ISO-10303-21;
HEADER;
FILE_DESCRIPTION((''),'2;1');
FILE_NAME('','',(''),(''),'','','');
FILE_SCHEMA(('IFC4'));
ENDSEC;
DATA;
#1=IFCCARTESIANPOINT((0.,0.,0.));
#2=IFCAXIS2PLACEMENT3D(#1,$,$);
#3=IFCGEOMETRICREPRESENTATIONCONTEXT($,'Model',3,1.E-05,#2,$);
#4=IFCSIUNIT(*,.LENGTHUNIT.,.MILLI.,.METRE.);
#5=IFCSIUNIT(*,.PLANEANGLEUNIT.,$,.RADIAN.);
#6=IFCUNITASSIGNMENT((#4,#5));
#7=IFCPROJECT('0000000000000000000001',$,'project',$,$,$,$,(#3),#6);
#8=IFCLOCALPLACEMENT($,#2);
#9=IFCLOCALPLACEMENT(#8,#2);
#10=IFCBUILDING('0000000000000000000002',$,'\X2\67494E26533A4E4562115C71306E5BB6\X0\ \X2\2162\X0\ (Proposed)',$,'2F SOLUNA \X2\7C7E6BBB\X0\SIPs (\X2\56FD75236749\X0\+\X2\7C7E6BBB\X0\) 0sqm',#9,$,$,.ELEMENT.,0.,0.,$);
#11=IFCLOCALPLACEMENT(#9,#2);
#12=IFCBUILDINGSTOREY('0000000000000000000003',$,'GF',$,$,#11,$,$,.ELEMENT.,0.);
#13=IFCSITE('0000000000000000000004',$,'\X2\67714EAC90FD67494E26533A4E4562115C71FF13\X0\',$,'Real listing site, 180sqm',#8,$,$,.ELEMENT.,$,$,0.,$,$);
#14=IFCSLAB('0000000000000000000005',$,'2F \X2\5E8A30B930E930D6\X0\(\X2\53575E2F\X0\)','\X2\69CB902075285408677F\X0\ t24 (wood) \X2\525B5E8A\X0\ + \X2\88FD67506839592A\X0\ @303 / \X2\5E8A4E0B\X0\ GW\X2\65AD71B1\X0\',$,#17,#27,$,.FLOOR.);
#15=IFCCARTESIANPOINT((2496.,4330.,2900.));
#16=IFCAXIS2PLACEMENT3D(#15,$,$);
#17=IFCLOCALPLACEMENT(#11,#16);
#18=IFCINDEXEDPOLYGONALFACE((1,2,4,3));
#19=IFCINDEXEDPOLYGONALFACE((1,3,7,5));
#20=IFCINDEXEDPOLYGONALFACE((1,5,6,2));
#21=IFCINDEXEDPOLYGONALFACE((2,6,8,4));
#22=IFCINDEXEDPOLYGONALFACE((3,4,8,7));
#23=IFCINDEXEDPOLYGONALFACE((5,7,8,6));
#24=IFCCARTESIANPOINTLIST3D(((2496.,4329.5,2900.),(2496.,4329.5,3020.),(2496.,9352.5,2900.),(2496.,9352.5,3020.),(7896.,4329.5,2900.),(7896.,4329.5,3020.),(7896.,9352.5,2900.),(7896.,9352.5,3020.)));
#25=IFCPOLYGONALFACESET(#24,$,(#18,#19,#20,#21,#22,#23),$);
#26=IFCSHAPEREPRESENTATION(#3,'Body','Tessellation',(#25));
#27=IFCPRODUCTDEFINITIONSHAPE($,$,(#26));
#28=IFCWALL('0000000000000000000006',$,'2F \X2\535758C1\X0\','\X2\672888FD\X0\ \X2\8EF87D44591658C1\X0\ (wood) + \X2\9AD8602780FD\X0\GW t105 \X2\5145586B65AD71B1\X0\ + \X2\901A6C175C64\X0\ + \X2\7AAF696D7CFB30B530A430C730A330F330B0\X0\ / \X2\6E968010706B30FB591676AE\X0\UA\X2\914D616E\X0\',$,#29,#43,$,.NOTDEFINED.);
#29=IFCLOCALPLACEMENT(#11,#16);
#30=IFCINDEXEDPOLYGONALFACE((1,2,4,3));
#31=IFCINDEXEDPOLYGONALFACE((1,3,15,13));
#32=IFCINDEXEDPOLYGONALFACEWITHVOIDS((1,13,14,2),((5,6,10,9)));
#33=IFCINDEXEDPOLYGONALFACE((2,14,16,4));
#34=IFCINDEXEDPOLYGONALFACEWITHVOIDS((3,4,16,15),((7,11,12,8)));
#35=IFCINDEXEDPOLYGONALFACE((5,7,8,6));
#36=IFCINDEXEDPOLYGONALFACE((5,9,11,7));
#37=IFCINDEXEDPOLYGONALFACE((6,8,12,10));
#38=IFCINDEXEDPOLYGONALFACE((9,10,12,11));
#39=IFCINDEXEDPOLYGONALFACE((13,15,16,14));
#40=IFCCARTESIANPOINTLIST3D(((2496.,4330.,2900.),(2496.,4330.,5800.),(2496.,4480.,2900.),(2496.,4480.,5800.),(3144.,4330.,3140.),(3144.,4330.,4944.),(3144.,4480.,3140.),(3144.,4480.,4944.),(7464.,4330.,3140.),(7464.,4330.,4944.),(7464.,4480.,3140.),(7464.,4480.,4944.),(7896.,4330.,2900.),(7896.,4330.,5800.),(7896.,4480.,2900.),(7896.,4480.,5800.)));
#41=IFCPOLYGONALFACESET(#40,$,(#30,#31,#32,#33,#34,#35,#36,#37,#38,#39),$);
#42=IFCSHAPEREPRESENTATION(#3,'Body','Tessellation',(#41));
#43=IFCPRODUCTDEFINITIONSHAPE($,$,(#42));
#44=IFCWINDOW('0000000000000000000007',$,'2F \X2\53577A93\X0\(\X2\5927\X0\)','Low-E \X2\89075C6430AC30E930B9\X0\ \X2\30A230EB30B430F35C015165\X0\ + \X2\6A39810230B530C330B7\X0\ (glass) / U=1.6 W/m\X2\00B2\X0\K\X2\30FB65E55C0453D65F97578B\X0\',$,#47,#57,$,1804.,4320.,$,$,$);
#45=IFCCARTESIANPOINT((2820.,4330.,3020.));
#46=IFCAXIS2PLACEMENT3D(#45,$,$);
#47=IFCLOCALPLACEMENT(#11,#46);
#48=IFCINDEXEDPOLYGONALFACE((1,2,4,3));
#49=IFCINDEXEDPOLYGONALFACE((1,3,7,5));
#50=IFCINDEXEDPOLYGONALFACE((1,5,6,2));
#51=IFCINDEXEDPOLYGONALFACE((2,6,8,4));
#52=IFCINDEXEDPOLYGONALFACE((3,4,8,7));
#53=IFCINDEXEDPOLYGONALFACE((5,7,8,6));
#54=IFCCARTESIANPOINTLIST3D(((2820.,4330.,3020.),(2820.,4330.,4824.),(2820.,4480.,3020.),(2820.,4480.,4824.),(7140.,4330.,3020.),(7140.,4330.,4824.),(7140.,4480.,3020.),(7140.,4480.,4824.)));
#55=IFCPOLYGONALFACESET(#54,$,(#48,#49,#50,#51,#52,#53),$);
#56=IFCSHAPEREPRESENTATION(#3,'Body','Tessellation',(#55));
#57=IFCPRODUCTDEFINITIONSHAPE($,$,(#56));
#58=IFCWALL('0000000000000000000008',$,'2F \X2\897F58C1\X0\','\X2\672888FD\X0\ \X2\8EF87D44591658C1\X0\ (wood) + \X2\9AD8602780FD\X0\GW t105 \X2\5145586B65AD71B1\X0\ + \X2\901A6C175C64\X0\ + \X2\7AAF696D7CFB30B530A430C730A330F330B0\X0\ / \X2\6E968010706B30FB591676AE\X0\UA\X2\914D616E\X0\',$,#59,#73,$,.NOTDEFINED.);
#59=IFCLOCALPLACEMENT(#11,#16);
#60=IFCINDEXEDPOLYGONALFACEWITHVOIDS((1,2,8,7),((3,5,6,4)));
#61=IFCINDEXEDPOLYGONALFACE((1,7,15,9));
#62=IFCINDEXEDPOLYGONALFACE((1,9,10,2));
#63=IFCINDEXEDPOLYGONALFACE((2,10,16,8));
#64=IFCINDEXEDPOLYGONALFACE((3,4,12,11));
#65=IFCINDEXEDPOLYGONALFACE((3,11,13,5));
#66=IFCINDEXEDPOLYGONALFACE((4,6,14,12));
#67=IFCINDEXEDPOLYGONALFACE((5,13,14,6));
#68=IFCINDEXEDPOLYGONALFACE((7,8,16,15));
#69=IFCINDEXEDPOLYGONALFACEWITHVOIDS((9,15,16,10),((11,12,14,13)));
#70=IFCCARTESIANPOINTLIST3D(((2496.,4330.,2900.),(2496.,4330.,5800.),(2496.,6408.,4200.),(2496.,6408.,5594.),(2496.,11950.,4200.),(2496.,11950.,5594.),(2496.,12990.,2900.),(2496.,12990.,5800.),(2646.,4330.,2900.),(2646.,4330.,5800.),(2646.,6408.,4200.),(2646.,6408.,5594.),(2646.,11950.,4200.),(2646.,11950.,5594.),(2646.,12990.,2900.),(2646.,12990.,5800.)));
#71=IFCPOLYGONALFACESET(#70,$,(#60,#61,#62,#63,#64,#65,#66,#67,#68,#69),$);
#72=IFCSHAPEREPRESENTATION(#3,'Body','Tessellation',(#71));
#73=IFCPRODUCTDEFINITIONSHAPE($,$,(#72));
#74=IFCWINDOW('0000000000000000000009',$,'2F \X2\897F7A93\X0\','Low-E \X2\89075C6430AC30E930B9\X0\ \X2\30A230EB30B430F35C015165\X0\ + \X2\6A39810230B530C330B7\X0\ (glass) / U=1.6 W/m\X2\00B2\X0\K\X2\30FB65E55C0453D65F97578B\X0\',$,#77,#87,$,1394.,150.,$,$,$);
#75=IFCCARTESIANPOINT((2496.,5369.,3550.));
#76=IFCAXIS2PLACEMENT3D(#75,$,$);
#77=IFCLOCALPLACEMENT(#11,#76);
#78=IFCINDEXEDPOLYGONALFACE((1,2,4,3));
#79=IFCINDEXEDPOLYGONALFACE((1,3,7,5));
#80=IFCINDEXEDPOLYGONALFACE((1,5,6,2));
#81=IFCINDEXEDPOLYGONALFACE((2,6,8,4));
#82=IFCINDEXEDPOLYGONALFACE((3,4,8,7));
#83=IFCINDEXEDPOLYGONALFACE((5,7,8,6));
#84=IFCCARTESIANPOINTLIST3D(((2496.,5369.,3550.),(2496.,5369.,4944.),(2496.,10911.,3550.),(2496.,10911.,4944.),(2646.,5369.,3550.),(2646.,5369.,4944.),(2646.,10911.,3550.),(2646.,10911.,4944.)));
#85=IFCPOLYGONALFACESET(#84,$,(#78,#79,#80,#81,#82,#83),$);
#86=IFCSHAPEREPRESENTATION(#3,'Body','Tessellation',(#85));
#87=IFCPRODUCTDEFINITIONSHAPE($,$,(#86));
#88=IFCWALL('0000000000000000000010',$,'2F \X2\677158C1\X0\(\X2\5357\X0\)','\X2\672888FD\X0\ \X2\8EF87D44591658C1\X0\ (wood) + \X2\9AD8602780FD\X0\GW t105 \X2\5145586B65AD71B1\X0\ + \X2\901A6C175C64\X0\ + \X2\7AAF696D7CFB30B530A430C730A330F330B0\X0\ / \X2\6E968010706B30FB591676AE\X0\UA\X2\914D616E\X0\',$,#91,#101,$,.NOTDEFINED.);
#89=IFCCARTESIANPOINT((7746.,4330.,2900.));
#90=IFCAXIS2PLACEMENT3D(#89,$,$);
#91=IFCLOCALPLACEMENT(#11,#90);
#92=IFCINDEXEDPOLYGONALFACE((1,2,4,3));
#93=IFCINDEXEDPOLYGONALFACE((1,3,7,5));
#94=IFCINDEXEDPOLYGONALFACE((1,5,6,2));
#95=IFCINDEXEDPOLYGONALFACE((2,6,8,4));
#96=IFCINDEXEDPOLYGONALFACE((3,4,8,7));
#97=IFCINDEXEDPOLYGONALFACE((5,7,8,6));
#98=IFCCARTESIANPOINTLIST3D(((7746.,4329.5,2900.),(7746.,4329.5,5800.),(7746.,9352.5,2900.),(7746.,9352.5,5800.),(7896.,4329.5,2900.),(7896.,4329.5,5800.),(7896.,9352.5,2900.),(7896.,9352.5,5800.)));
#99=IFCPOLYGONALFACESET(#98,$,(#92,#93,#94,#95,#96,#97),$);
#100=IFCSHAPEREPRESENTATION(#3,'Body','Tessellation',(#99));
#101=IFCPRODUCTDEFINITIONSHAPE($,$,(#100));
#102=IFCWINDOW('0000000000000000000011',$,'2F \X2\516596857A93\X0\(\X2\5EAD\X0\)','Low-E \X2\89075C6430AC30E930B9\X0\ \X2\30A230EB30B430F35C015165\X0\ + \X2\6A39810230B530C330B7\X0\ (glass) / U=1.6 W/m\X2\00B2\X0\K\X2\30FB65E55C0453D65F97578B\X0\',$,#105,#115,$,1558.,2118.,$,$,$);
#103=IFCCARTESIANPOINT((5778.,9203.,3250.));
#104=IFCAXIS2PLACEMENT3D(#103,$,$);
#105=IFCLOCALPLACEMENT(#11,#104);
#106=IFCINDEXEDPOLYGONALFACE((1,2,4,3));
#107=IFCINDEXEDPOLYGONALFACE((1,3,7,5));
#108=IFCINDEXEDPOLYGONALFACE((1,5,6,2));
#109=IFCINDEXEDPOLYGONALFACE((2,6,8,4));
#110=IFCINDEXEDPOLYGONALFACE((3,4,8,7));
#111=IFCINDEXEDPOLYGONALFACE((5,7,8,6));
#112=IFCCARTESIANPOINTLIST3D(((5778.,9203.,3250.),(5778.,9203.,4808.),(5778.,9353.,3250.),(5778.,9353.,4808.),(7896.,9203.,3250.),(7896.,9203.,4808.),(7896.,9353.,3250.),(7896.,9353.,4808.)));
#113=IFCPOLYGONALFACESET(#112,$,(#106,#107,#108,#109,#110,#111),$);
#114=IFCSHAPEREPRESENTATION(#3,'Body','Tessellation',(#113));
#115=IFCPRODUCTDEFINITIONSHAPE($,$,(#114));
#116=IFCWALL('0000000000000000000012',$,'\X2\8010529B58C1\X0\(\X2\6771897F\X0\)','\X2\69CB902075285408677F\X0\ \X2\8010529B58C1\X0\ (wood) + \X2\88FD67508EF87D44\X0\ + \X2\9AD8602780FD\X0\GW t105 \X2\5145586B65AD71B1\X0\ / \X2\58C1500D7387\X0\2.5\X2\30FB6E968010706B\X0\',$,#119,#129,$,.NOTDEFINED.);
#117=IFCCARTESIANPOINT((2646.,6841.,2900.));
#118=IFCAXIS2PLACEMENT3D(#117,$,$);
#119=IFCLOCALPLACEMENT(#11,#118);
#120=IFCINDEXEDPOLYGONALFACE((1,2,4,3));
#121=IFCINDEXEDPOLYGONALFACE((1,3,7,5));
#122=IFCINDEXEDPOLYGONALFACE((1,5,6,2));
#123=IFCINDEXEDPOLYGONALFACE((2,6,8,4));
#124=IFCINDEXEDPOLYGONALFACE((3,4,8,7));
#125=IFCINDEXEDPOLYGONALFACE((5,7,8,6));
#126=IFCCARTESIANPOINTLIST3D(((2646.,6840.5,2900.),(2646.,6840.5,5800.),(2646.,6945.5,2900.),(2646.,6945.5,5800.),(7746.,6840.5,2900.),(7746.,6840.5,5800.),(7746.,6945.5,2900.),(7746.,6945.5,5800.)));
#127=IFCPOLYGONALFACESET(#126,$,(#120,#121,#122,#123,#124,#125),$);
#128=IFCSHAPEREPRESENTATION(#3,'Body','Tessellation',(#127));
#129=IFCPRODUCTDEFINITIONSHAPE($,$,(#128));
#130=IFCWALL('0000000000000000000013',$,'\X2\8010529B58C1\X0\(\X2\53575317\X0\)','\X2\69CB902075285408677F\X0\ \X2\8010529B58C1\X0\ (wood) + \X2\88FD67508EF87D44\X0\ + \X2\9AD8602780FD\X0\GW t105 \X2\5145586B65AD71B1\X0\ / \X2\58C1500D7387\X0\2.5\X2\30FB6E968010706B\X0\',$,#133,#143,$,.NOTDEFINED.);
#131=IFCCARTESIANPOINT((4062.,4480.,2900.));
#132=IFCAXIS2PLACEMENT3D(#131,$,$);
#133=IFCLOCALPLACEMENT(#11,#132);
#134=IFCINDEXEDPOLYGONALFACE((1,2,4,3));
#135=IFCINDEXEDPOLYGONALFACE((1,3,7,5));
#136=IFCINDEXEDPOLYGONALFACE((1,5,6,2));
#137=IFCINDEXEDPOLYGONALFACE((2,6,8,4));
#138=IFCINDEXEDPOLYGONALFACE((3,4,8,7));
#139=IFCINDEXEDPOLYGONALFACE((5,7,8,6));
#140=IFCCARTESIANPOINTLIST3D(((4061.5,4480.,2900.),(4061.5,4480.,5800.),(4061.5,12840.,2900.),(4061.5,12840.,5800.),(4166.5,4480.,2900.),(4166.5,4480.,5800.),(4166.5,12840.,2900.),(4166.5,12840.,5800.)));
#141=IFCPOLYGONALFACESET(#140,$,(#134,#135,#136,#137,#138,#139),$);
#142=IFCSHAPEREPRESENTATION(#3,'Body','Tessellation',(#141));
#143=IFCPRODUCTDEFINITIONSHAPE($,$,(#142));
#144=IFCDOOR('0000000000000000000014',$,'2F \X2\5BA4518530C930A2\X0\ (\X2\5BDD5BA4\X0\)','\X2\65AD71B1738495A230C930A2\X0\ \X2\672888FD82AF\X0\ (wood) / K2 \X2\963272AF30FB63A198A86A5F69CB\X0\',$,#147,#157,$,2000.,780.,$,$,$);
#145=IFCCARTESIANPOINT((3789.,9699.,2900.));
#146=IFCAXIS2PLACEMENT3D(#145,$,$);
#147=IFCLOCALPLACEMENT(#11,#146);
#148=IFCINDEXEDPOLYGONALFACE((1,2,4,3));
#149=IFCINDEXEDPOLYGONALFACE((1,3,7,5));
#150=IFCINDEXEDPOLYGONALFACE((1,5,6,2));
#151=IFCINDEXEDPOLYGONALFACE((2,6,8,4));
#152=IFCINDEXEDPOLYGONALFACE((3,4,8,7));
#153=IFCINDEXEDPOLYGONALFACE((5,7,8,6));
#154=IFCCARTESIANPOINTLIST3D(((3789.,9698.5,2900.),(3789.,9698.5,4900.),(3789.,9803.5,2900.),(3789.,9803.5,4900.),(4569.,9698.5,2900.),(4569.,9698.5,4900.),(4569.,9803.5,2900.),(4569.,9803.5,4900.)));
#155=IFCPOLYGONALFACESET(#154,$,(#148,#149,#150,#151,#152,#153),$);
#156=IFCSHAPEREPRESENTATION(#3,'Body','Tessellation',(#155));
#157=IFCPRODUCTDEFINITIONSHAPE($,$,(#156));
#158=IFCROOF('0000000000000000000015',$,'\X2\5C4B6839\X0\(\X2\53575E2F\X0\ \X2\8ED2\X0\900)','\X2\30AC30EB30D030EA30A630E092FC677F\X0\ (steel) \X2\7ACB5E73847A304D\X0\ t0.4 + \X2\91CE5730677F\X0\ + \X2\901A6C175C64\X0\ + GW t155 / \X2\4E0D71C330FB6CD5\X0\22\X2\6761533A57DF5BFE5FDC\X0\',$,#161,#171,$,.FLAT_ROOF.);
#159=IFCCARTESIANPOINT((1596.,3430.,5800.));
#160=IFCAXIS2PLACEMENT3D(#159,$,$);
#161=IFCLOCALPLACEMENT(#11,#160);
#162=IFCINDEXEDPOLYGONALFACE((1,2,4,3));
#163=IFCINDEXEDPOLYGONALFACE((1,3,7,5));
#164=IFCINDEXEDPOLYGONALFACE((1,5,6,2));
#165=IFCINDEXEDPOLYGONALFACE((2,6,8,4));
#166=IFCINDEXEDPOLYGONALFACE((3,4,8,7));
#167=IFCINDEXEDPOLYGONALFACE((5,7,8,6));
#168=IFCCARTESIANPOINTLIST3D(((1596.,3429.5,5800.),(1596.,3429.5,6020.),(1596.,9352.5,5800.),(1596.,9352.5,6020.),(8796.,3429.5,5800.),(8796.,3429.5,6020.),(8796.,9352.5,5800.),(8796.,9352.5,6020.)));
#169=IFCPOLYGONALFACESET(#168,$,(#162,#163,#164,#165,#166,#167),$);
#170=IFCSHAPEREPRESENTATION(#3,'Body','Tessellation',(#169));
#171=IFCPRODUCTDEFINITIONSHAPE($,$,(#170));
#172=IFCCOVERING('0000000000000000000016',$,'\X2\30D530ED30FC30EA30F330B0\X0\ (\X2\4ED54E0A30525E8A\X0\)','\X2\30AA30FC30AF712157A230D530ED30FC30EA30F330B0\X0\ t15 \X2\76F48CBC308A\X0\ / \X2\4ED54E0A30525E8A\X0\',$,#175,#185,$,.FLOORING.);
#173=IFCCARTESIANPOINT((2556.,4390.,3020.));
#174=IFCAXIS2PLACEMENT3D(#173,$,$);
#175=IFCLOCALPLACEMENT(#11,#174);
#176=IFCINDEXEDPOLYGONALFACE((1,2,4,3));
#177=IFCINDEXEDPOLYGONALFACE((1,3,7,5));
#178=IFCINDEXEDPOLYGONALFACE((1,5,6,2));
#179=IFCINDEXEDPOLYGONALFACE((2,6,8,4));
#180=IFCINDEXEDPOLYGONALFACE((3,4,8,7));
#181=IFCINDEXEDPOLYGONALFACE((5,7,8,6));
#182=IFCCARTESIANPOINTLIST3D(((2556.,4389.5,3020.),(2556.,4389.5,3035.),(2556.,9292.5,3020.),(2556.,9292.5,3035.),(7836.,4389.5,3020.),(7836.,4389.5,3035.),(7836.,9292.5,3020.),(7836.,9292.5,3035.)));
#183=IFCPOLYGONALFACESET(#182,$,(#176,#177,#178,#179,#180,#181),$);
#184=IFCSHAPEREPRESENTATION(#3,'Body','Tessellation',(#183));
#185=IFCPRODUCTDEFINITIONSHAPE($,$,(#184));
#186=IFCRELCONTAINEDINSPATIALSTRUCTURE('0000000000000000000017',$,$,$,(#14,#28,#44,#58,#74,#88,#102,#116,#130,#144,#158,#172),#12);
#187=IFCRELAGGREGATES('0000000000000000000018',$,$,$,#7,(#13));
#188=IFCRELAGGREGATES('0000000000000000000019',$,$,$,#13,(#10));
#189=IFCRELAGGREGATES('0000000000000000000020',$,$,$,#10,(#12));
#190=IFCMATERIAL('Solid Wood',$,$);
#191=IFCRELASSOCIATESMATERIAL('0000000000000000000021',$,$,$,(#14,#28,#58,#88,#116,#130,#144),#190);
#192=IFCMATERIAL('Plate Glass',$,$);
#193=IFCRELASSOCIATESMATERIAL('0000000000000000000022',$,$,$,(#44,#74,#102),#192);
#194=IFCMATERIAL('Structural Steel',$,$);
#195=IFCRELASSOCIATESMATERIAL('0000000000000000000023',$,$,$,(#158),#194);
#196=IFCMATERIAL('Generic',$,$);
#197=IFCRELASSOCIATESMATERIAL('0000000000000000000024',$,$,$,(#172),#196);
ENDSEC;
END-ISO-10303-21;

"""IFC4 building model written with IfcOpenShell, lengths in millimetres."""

from ifc_helpers import new_model, si_unit, frame, frame_2d, origin, place, context, project, spatial, rectangle, extrude, material, element, fill, save


model = new_model("IFC4")

# Units and contexts
model_context = context("Model", 3, precision=1e-05, world=origin())
ifc_project = project(units=[si_unit("LENGTHUNIT", "METRE", prefix="MILLI"), si_unit("PLANEANGLEUNIT", "RADIAN")], contexts=[model_context])

# Site, building, storey
site_placement = place(None, origin())
site = spatial("IfcSite", under=ifc_project, at=site_placement, Name="東京都杉並区久我山３", ObjectType="Real listing site, 180sqm", CompositionType="ELEMENT", RefElevation=0.0)
building_placement = place(site_placement, origin())
building = spatial("IfcBuilding", under=site, at=building_placement, Name="杉並区久我山の家 Ⅲ (Proposed)", ObjectType="2F SOLUNA 籾殻SIPs (国産杉+籾殻) 0sqm", CompositionType="ELEMENT", ElevationOfRefHeight=0.0, ElevationOfTerrain=0.0)
storey_placement = place(building_placement, origin())
storey = spatial("IfcBuildingStorey", under=building, at=storey_placement, Name="GF", CompositionType="ELEMENT", Elevation=0.0)

# Slab
ifc_material_1 = material(Name="Solid Wood")
slab_placement = place(storey_placement, frame((2496.0, 4330.0, 2900.0)))
element("IfcSlab", 1, at=slab_placement, inside=storey, material=ifc_material_1, Name="2F 床スラブ(南帯)", Description="構造用合板 t24 (wood) 剛床 + 製材根太 @303 / 床下 GW断熱", PredefinedType="FLOOR", context=model_context, shape_type="SweptSolid", body=[
    extrude(rectangle(XDim=5400.0, YDim=5023.0, at=frame_2d((2700.0, 2511.0))), frame((2496.0, 4330.0, 2900.0)), (0.0, 0.0, 1.0), 120.0),
])

# Walls, openings, windows
wall_1_placement = place(storey_placement, frame((2496.0, 4330.0, 2900.0)))
wall_1 = element("IfcWall", 2, at=wall_1_placement, inside=storey, material=ifc_material_1, Name="2F 南壁", Description="木製 軸組外壁 (wood) + 高性能GW t105 充填断熱 + 通気層 + 窯業系サイディング / 準耐火・外皮UA配慮", PredefinedType="NOTDEFINED", context=model_context, shape_type="SweptSolid", body=[
    extrude(rectangle(XDim=5400.0, YDim=150.0, at=frame_2d((2700.0, 75.0))), frame((2496.0, 4330.0, 2900.0)), (0.0, 0.0, 1.0), 2900.0),
])
opening_1_placement = place(storey_placement, frame((2820.0, 4330.0, 3020.0)))
opening_1 = element("IfcOpeningElement", 3, at=opening_1_placement, cuts=wall_1, PredefinedType="NOTDEFINED", context=model_context, shape_type="SweptSolid", body=[
    extrude(rectangle(XDim=4320.0, YDim=150.0, at=frame_2d((2160.0, 75.0))), frame((2820.0, 4330.0, 3020.0)), (0.0, 0.0, 1.0), 1804.0),
])
ifc_material_2 = material(Name="Plate Glass")
window_1_placement = place(storey_placement, frame((2820.0, 4330.0, 3020.0)))
window_1 = element("IfcWindow", 4, at=window_1_placement, inside=storey, material=ifc_material_2, Name="2F 南窓(大)", Description="Low-E 複層ガラス アルゴン封入 + 樹脂サッシ (glass) / U=1.6 W/m²K・日射取得型", OverallHeight=1804.0, OverallWidth=4320.0, context=model_context, shape_type="SweptSolid", body=[
    extrude(rectangle(XDim=4320.0, YDim=150.0, at=frame_2d((2160.0, 75.0))), frame((2820.0, 4330.0, 3020.0)), (0.0, 0.0, 1.0), 1804.0),
])
fill(opening_1, window_1)
wall_2_placement = place(storey_placement, frame((2496.0, 4330.0, 2900.0)))
wall_2 = element("IfcWall", 5, at=wall_2_placement, inside=storey, material=ifc_material_1, Name="2F 西壁", Description="木製 軸組外壁 (wood) + 高性能GW t105 充填断熱 + 通気層 + 窯業系サイディング / 準耐火・外皮UA配慮", PredefinedType="NOTDEFINED", context=model_context, shape_type="SweptSolid", body=[
    extrude(rectangle(XDim=150.0, YDim=8660.0, at=frame_2d((75.0, 4330.0))), frame((2496.0, 4330.0, 2900.0)), (0.0, 0.0, 1.0), 2900.0),
])
opening_2_placement = place(storey_placement, frame((2496.0, 5369.0, 3550.0)))
opening_2 = element("IfcOpeningElement", 6, at=opening_2_placement, cuts=wall_2, PredefinedType="NOTDEFINED", context=model_context, shape_type="SweptSolid", body=[
    extrude(rectangle(XDim=150.0, YDim=5542.0, at=frame_2d((75.0, 2771.0))), frame((2496.0, 5369.0, 3550.0)), (0.0, 0.0, 1.0), 1394.0),
])
window_2_placement = place(storey_placement, frame((2496.0, 5369.0, 3550.0)))
window_2 = element("IfcWindow", 7, at=window_2_placement, inside=storey, material=ifc_material_2, Name="2F 西窓", Description="Low-E 複層ガラス アルゴン封入 + 樹脂サッシ (glass) / U=1.6 W/m²K・日射取得型", OverallHeight=1394.0, OverallWidth=150.0, context=model_context, shape_type="SweptSolid", body=[
    extrude(rectangle(XDim=150.0, YDim=5542.0, at=frame_2d((75.0, 2771.0))), frame((2496.0, 5369.0, 3550.0)), (0.0, 0.0, 1.0), 1394.0),
])
fill(opening_2, window_2)
wall_3_placement = place(storey_placement, frame((7746.0, 4330.0, 2900.0)))
wall_3 = element("IfcWall", 8, at=wall_3_placement, inside=storey, material=ifc_material_1, Name="2F 東壁(南)", Description="木製 軸組外壁 (wood) + 高性能GW t105 充填断熱 + 通気層 + 窯業系サイディング / 準耐火・外皮UA配慮", PredefinedType="NOTDEFINED", context=model_context, shape_type="SweptSolid", body=[
    extrude(rectangle(XDim=150.0, YDim=5023.0, at=frame_2d((75.0, 2511.0))), frame((7746.0, 4330.0, 2900.0)), (0.0, 0.0, 1.0), 2900.0),
])
opening_3_placement = place(storey_placement, frame((5778.0, 9203.0, 3250.0)))
opening_3 = element("IfcOpeningElement", 9, at=opening_3_placement, cuts=wall_3, PredefinedType="NOTDEFINED", context=model_context, shape_type="SweptSolid", body=[
    extrude(rectangle(XDim=2118.0, YDim=150.0, at=frame_2d((1059.0, 75.0))), frame((5778.0, 9203.0, 3250.0)), (0.0, 0.0, 1.0), 1558.0),
])
window_3_placement = place(storey_placement, frame((5778.0, 9203.0, 3250.0)))
window_3 = element("IfcWindow", 10, at=window_3_placement, inside=storey, material=ifc_material_2, Name="2F 入隅窓(庭)", Description="Low-E 複層ガラス アルゴン封入 + 樹脂サッシ (glass) / U=1.6 W/m²K・日射取得型", OverallHeight=1558.0, OverallWidth=2118.0, context=model_context, shape_type="SweptSolid", body=[
    extrude(rectangle(XDim=2118.0, YDim=150.0, at=frame_2d((1059.0, 75.0))), frame((5778.0, 9203.0, 3250.0)), (0.0, 0.0, 1.0), 1558.0),
])
fill(opening_3, window_3)

# Wall
wall_4_placement = place(storey_placement, frame((2646.0, 6841.0, 2900.0)))
element("IfcWall", 11, at=wall_4_placement, inside=storey, material=ifc_material_1, Name="耐力壁(東西)", Description="構造用合板 耐力壁 (wood) + 製材軸組 + 高性能GW t105 充填断熱 / 壁倍率2.5・準耐火", PredefinedType="NOTDEFINED", context=model_context, shape_type="SweptSolid", body=[
    extrude(rectangle(XDim=5100.0, YDim=105.0, at=frame_2d((2550.0, 52.0))), frame((2646.0, 6841.0, 2900.0)), (0.0, 0.0, 1.0), 2900.0),
])

# Wall, opening, door
wall_5_placement = place(storey_placement, frame((4062.0, 4480.0, 2900.0)))
wall_5 = element("IfcWall", 12, at=wall_5_placement, inside=storey, material=ifc_material_1, Name="耐力壁(南北)", Description="構造用合板 耐力壁 (wood) + 製材軸組 + 高性能GW t105 充填断熱 / 壁倍率2.5・準耐火", PredefinedType="NOTDEFINED", context=model_context, shape_type="SweptSolid", body=[
    extrude(rectangle(XDim=105.0, YDim=8360.0, at=frame_2d((52.0, 4180.0))), frame((4062.0, 4480.0, 2900.0)), (0.0, 0.0, 1.0), 2900.0),
])
opening_4_placement = place(storey_placement, frame((3789.0, 9699.0, 2900.0)))
opening_4 = element("IfcOpeningElement", 13, at=opening_4_placement, cuts=wall_5, PredefinedType="NOTDEFINED", context=model_context, shape_type="SweptSolid", body=[
    extrude(rectangle(XDim=780.0, YDim=105.0, at=frame_2d((390.0, 52.0))), frame((3789.0, 9699.0, 2900.0)), (0.0, 0.0, 1.0), 2000.0),
])
door_placement = place(storey_placement, frame((3789.0, 9699.0, 2900.0)))
door = element("IfcDoor", 14, at=door_placement, inside=storey, material=ifc_material_1, Name="2F 室内ドア (寝室)", Description="断熱玄関ドア 木製芯 (wood) / K2 防犯・採風機構", OverallHeight=2000.0, OverallWidth=780.0, context=model_context, shape_type="SweptSolid", body=[
    extrude(rectangle(XDim=780.0, YDim=105.0, at=frame_2d((390.0, 52.0))), frame((3789.0, 9699.0, 2900.0)), (0.0, 0.0, 1.0), 2000.0),
])
fill(opening_4, door)

# Roof
ifc_material_3 = material(Name="Structural Steel")
for number, where, name in (
    (15, (1596.0, 3430.0, 5800.0), "屋根(南帯 軒900)"),
):
    element("IfcRoof", number, at=place(storey_placement, frame(where)), inside=storey, material=ifc_material_3, Name=name, Description="ガルバリウム鋼板 (steel) 立平葺き t0.4 + 野地板 + 通気層 + GW t155 / 不燃・法22条区域対応", PredefinedType="FLAT_ROOF", context=model_context, shape_type="SweptSolid", body=[
        extrude(rectangle(XDim=7200.0, YDim=5923.0, at=frame_2d((3600.0, 2961.0))), frame((1596.0, 3430.0, 5800.0)), (0.0, 0.0, 1.0), 220.0),
    ])

# Covering
ifc_material_4 = material(Name="Generic")
covering_placement = place(storey_placement, frame((2556.0, 4390.0, 3020.0)))
element("IfcCovering", 16, at=covering_placement, inside=storey, material=ifc_material_4, Name="フローリング (仕上げ床)", Description="オーク無垢フローリング t15 直貼り / 仕上げ床", PredefinedType="FLOORING", context=model_context, shape_type="SweptSolid", body=[
    extrude(rectangle(XDim=5280.0, YDim=4903.0, at=frame_2d((2640.0, 2451.0))), frame((2556.0, 4390.0, 3020.0)), (0.0, 0.0, 1.0), 15.0),
])

save(model, "model.ifc")
